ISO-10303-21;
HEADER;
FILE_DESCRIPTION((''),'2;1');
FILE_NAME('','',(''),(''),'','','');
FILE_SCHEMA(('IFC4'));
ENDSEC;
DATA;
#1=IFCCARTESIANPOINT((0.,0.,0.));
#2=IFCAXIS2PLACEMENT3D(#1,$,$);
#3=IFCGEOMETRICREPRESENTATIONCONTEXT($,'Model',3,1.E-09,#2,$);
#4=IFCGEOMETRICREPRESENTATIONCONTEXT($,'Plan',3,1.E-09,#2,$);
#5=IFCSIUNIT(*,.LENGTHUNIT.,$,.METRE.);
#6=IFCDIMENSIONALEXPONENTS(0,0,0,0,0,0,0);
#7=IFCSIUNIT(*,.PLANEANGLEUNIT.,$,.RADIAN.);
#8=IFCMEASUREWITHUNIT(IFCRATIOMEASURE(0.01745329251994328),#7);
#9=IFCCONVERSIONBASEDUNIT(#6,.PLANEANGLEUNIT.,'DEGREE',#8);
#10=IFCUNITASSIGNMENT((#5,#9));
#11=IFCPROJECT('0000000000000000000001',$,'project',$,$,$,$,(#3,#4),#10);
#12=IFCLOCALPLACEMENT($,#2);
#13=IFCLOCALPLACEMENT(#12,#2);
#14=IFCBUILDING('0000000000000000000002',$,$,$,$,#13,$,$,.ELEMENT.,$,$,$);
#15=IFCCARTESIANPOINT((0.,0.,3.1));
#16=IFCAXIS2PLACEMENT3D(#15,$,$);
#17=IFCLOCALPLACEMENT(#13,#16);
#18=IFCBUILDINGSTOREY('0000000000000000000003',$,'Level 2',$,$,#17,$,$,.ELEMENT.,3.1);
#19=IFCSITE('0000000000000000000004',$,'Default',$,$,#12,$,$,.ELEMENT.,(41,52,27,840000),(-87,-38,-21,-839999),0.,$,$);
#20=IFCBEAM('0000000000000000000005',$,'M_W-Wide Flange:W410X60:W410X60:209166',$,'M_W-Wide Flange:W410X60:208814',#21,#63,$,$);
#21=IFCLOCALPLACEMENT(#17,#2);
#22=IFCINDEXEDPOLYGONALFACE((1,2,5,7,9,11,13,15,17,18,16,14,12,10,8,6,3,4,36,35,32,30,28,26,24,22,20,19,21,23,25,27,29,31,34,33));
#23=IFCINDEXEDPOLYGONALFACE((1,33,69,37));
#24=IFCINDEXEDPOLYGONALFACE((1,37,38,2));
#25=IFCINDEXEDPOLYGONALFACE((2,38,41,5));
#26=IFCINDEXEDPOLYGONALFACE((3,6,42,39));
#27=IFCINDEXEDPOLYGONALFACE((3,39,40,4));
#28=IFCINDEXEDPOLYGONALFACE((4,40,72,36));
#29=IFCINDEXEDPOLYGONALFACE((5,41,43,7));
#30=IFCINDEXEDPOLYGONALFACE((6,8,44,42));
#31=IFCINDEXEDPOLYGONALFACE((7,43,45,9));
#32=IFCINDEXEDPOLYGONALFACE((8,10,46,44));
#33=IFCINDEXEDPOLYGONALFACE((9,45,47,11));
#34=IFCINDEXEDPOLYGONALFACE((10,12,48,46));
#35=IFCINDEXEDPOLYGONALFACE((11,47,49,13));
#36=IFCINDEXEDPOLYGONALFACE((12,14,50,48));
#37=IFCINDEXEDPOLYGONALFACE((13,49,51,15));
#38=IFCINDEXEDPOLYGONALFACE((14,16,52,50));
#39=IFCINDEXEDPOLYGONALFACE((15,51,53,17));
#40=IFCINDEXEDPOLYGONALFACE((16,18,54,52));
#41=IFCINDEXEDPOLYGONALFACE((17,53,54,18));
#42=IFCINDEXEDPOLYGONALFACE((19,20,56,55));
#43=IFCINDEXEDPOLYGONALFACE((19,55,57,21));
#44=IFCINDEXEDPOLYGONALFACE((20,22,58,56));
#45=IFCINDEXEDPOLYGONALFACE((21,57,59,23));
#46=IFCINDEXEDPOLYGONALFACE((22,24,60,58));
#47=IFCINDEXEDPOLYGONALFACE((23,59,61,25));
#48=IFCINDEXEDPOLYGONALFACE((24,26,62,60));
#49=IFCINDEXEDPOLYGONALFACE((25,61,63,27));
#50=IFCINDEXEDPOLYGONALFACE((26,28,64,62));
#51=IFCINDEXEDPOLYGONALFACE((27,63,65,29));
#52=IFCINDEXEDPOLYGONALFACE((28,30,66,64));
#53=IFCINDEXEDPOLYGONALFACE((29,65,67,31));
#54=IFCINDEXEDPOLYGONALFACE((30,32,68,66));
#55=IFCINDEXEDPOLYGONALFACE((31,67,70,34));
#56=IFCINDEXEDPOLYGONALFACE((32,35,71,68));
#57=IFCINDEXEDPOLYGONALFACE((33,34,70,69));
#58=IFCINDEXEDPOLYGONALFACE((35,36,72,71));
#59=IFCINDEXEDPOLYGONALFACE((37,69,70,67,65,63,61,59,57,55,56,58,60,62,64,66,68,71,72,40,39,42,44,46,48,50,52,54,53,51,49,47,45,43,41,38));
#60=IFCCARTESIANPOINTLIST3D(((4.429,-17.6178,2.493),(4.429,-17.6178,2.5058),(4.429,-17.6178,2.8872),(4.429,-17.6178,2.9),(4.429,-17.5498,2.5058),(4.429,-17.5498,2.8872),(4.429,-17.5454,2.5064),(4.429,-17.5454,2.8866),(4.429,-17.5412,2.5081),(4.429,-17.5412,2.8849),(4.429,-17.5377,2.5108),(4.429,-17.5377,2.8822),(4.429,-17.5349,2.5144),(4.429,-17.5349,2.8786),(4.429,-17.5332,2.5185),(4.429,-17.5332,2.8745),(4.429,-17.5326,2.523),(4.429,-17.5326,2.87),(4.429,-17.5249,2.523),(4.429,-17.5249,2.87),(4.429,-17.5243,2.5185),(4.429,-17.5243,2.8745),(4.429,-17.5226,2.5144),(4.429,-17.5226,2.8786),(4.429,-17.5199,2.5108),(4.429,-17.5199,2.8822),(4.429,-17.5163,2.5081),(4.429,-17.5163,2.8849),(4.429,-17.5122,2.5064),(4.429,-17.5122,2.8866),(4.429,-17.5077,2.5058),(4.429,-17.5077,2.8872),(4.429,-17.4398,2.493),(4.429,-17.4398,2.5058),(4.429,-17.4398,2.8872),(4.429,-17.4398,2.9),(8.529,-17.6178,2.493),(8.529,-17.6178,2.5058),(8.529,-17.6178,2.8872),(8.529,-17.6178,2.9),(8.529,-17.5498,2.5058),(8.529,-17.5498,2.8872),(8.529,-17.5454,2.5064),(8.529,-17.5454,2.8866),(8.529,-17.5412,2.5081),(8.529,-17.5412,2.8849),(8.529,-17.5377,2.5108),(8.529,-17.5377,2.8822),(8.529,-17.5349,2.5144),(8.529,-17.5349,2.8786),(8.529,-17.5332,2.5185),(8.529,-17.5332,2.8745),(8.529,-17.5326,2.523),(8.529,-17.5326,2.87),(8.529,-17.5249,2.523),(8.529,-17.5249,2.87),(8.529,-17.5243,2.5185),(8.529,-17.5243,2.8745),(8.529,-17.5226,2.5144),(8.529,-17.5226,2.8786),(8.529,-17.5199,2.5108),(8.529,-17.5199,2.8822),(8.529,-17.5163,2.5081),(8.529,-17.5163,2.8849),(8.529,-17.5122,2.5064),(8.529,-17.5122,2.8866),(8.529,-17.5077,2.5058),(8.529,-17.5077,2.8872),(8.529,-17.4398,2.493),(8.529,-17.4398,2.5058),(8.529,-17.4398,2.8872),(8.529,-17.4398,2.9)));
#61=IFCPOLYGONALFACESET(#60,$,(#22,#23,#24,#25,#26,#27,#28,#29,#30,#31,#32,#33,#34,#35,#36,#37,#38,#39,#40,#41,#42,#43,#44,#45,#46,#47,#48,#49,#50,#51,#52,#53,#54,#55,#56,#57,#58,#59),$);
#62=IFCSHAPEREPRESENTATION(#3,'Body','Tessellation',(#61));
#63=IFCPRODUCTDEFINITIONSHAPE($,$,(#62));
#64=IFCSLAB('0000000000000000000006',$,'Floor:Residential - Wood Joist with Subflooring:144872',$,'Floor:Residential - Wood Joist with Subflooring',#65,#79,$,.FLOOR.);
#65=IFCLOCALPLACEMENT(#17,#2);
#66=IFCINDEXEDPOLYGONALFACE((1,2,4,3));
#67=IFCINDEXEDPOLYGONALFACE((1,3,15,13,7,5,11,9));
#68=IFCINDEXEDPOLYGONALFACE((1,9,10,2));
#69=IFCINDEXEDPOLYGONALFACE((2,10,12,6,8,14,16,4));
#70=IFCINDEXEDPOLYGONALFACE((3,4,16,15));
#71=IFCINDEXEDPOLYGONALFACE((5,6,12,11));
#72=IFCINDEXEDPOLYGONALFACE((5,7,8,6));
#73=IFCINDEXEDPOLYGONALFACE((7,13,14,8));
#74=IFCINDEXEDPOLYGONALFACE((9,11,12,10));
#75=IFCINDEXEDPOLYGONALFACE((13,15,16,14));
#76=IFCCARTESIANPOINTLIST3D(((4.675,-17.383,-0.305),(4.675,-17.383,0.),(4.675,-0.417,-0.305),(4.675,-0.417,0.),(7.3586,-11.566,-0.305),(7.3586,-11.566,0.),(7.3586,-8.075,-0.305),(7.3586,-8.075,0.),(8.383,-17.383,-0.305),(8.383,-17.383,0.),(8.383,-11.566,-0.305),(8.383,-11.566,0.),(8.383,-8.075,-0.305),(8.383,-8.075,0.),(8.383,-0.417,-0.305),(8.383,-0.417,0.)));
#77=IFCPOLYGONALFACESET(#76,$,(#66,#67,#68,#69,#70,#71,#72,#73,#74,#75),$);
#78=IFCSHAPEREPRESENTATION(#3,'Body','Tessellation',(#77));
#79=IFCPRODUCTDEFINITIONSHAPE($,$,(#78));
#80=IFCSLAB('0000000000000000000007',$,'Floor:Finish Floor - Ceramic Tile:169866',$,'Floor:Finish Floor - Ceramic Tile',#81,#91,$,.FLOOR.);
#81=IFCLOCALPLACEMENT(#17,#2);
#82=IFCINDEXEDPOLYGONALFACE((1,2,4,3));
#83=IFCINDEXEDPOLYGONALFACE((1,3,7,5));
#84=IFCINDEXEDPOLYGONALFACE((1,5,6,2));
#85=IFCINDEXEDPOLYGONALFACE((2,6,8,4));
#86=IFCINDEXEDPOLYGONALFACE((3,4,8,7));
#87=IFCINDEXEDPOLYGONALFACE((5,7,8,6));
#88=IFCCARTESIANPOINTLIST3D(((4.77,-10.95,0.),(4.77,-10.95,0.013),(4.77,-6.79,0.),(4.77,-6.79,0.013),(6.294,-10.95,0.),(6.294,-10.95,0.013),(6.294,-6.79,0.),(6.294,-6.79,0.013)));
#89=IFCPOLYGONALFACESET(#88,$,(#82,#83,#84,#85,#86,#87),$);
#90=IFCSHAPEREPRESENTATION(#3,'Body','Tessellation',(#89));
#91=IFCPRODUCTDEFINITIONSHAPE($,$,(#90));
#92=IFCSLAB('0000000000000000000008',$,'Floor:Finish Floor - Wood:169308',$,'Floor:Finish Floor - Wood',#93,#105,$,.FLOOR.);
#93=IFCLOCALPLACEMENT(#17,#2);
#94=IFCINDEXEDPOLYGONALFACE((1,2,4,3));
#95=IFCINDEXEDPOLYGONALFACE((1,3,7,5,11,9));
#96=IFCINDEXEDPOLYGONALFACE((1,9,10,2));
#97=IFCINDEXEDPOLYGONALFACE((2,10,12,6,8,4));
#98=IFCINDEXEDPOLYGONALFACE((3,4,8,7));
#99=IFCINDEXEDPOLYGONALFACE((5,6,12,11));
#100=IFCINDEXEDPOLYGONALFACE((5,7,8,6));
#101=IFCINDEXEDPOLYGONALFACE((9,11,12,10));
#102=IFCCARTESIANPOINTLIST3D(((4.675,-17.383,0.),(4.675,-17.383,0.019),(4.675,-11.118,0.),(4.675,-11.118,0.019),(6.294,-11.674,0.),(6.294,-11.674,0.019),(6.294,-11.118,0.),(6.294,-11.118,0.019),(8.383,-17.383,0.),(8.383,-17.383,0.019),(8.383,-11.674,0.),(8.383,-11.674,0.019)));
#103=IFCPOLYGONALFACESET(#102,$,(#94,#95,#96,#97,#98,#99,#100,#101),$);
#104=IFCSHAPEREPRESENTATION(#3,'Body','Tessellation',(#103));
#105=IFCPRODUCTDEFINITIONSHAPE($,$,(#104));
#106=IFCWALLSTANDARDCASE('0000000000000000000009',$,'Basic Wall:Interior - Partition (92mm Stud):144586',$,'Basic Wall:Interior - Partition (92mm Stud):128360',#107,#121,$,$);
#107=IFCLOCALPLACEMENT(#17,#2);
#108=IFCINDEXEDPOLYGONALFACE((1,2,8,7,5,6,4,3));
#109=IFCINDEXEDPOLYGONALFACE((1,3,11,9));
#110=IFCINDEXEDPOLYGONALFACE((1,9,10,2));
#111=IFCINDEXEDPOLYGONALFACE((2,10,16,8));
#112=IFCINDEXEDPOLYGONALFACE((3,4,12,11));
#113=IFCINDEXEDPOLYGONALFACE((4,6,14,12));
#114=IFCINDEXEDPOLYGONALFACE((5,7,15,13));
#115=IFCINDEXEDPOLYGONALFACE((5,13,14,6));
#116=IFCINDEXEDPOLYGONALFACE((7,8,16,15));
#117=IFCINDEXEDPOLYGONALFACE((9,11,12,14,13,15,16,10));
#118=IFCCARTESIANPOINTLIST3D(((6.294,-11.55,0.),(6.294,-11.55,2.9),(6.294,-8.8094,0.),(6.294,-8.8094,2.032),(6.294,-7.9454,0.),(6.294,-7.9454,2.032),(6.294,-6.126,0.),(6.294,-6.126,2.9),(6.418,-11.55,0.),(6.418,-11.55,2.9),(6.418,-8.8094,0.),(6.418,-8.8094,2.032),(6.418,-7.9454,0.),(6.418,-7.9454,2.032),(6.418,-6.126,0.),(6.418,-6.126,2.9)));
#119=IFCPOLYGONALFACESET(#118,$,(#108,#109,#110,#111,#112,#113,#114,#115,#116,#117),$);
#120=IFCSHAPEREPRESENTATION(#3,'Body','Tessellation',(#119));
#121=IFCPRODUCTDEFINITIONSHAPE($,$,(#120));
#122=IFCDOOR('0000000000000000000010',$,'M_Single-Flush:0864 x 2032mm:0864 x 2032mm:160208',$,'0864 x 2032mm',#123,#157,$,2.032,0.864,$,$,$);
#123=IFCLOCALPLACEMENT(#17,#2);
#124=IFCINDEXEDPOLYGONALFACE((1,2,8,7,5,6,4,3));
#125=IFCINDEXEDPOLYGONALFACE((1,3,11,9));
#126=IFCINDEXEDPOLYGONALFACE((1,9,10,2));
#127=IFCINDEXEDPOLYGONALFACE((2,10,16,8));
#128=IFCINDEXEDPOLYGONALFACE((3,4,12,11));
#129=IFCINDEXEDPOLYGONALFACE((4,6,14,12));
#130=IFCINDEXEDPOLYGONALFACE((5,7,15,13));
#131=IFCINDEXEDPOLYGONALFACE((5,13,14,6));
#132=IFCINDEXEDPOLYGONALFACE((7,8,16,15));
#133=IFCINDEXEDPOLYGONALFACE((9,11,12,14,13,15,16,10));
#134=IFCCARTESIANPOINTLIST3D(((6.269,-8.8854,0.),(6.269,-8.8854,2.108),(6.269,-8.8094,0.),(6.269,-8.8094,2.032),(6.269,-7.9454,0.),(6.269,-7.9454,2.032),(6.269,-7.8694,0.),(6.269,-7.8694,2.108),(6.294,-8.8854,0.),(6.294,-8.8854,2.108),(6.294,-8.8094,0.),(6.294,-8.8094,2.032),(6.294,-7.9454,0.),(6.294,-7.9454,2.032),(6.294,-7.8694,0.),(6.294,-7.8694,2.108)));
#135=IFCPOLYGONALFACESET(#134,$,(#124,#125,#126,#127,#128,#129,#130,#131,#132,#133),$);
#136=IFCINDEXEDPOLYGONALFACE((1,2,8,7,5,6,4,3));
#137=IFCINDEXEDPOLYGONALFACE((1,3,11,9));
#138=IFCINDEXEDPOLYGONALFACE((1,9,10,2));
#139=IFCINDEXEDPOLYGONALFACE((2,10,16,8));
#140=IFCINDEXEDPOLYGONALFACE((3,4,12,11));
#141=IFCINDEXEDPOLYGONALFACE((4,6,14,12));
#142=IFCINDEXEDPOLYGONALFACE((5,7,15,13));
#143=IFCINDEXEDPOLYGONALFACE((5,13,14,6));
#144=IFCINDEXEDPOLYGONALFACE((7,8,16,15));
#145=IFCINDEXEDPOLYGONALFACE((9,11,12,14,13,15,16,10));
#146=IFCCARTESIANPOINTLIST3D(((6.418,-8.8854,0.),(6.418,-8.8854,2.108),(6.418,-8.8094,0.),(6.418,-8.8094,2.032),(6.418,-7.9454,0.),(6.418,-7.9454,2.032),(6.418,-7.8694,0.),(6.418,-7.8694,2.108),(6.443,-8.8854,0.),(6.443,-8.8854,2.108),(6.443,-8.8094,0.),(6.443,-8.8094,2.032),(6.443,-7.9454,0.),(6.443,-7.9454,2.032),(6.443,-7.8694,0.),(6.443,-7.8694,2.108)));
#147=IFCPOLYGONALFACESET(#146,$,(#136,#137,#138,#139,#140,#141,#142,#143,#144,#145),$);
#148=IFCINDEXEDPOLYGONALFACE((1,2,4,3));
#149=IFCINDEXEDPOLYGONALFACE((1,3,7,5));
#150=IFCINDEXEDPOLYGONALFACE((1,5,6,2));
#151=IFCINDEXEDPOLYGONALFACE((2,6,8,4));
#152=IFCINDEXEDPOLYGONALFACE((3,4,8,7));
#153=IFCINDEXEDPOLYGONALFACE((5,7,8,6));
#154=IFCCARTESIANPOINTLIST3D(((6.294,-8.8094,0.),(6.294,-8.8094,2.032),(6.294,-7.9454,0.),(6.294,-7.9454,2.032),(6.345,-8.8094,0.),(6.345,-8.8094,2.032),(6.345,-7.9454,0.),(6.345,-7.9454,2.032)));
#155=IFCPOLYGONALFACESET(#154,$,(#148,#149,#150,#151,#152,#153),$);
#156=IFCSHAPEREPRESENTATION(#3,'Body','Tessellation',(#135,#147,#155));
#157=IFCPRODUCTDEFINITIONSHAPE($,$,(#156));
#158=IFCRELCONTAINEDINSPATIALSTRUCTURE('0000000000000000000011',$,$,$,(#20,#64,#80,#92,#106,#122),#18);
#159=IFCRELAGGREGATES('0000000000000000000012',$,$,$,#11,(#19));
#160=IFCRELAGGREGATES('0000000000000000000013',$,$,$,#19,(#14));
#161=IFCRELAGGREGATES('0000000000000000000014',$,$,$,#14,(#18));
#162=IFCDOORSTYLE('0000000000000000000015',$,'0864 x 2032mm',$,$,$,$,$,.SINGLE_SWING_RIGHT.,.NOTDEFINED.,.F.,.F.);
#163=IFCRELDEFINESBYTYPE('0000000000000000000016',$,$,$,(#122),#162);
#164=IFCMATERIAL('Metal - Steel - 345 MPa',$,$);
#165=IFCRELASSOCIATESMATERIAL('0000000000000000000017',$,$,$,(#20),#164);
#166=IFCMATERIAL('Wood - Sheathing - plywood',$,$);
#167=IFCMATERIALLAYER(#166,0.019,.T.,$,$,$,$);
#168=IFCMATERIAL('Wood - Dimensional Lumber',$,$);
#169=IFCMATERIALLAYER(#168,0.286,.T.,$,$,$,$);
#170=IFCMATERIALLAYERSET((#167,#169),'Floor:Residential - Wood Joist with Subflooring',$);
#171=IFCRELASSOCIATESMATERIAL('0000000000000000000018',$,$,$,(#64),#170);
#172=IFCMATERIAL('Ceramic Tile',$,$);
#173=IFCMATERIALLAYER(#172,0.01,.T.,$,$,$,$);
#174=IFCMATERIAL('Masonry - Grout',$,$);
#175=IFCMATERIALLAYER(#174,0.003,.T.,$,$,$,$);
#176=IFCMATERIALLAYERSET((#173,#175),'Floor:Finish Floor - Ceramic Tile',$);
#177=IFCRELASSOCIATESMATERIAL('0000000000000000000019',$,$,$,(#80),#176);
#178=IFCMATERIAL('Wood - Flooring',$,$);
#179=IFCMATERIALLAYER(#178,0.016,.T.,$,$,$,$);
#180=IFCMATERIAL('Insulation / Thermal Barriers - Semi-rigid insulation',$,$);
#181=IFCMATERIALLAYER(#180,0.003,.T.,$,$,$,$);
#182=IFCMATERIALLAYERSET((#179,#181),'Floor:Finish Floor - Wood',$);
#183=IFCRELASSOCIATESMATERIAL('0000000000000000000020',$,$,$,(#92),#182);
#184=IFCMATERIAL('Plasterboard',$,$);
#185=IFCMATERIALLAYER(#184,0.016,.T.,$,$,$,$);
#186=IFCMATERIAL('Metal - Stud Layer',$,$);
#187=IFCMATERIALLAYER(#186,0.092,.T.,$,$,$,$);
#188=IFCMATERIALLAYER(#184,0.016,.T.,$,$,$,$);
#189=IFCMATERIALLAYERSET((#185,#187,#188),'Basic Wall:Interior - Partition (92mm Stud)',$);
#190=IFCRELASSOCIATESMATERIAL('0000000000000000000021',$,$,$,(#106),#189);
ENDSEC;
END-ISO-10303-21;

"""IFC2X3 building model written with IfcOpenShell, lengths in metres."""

from ifc_helpers import new_model, entity, si_unit, converted_unit, frame, frame_2d, origin, origin_2d_with_axis, place, context, project, spatial, polyline, circle_curve, parameter, trimmed, segment, composite_curve, rectangle, outline, extrude, source, transform, mapped, material, layer, layer_set, layer_usage, type_object, type_shapes, element, fill, save


model = new_model("IFC2X3")

# Units and contexts
model_context = context("Model", 3, precision=1e-09, world=origin())
plan_context = context("Plan", 3, precision=1e-09, world=origin())
ifc_project = project(units=[si_unit("LENGTHUNIT", "METRE"), converted_unit("PLANEANGLEUNIT", "DEGREE", entity("IfcRatioMeasure", 0.01745329251994328), si_unit("PLANEANGLEUNIT", "RADIAN"), dimensions=[0, 0, 0, 0, 0, 0, 0])], contexts=[model_context, plan_context])

# Site, building, storey
site_placement = place(None, origin())
site = spatial("IfcSite", under=ifc_project, at=site_placement, Name="Default", CompositionType="ELEMENT", RefLatitude=(41, 52, 27, 840000), RefLongitude=(-87, -38, -21, -839999), RefElevation=0.0)
building_placement = place(site_placement, origin())
building = spatial("IfcBuilding", under=site, at=building_placement, CompositionType="ELEMENT")
storey_placement = place(building_placement, frame((0.0, 0.0, 3.1)))
storey = spatial("IfcBuildingStorey", under=building, at=storey_placement, Name="Level 2", CompositionType="ELEMENT", Elevation=3.1)

# Beam
ifc_material_1 = material(Name="Metal - Steel - 345 MPa")
beam_placement = place(storey_placement, frame((4.429, -17.5288, 2.9), z_axis=(0.0, 0.0, 1.0), x_axis=(0.0, -1.0, 0.0)))
element("IfcBeam", 1, at=beam_placement, inside=storey, material=ifc_material_1, Name="M_W-Wide Flange:W410X60:W410X60:209166", ObjectType="M_W-Wide Flange:W410X60:208814", context=model_context, shape_type="SweptSolid", body=[
    extrude(outline(composite_curve([segment(polyline([(-0.089, -0.1907), (-0.089, -0.2035)]), True, "CONTINUOUS"), segment(polyline([(-0.089, -0.2035), (0.089, -0.2035)]), True, "CONTINUOUS"), segment(polyline([(0.089, -0.2035), (0.089, -0.1907)]), True, "CONTINUOUS"), segment(polyline([(0.089, -0.1907), (0.021, -0.1907)]), True, "CONTINUOUS"), segment(trimmed(circle_curve(frame_2d((0.021, -0.1735), x_axis=(0.0, -1.0)), 0.0172), [parameter(270.0)], [parameter(360.0)], True, "PARAMETER"), False, "CONTINUOUS"), segment(polyline([(0.0038, -0.1735), (0.0038, 0.1735)]), True, "CONTINUOUS"), segment(trimmed(circle_curve(frame_2d((0.021, 0.1735), x_axis=(-1.0, 0.0)), 0.0172), [parameter(270.0)], [parameter(360.0)], True, "PARAMETER"), False, "CONTINUOUS"), segment(polyline([(0.021, 0.1907), (0.089, 0.1907)]), True, "CONTINUOUS"), segment(polyline([(0.089, 0.1907), (0.089, 0.2035)]), True, "CONTINUOUS"), segment(polyline([(0.089, 0.2035), (-0.089, 0.2035)]), True, "CONTINUOUS"), segment(polyline([(-0.089, 0.2035), (-0.089, 0.1907)]), True, "CONTINUOUS"), segment(polyline([(-0.089, 0.1907), (-0.0211, 0.1907)]), True, "CONTINUOUS"), segment(trimmed(circle_curve(frame_2d((-0.0211, 0.1735), x_axis=(0.0, 1.0)), 0.0172), [parameter(270.0)], [parameter(0.0)], True, "PARAMETER"), False, "CONTINUOUS"), segment(polyline([(-0.0039, 0.1735), (-0.0039, -0.1735)]), True, "CONTINUOUS"), segment(trimmed(circle_curve(frame_2d((-0.0211, -0.1735), x_axis=(1.0, 0.0)), 0.0172), [parameter(270.0)], [parameter(0.0)], True, "PARAMETER"), False, "CONTINUOUS"), segment(polyline([(-0.0211, -0.1907), (-0.089, -0.1907)]), True, "CONTINUOUS")], self_intersect=False)), frame((0.0, 0.0, -0.2035), z_axis=(0.0, -1.0, 0.0), x_axis=(1.0, 0.0, 0.0)), (0.0, 0.0, -1.0), 4.1),
])

# Slabs
ifc_material_2 = material(Name="Wood - Sheathing - plywood")
ifc_layer_1 = layer(ifc_material_2, 0.019, ventilated=True)
ifc_material_3 = material(Name="Wood - Dimensional Lumber")
ifc_layer_2 = layer(ifc_material_3, 0.286, ventilated=True)
ifc_layer_set_1 = layer_set([ifc_layer_1, ifc_layer_2], Name="Floor:Residential - Wood Joist with Subflooring")
ifc_layer_usage_1 = layer_usage(ifc_layer_set_1, "AXIS3", "POSITIVE", 0.0)
slab_1_placement = place(storey_placement, frame((4.675, -17.383, -0.305)))
element("IfcSlab", 2, at=slab_1_placement, inside=storey, material=ifc_layer_usage_1, Name="Floor:Residential - Wood Joist with Subflooring:144872", ObjectType="Floor:Residential - Wood Joist with Subflooring", PredefinedType="FLOOR", context=model_context, shape_type="SweptSolid", body=[
    extrude(outline(polyline([(-1.854, 8.483), (-1.854, 0.825), (-0.8296, 0.825), (-0.8296, -2.666), (-1.854, -2.666), (-1.854, -8.483), (1.854, -8.483), (1.854, 8.483), (-1.854, 8.483)])), frame((1.854, 8.483, 0.305), z_axis=(0.0, 0.0, -1.0), x_axis=(-1.0, 0.0, 0.0)), (0.0, 0.0, 1.0), 0.305),
])
ifc_material_4 = material(Name="Wood - Flooring")
ifc_layer_3 = layer(ifc_material_4, 0.016, ventilated=True)
ifc_material_5 = material(Name="Insulation / Thermal Barriers - Semi-rigid insulation")
ifc_layer_4 = layer(ifc_material_5, 0.003, ventilated=True)
ifc_layer_set_2 = layer_set([ifc_layer_3, ifc_layer_4], Name="Floor:Finish Floor - Wood")
ifc_layer_usage_2 = layer_usage(ifc_layer_set_2, "AXIS3", "POSITIVE", 0.0)
ifc_material_6 = material(Name="Ceramic Tile")
ifc_layer_5 = layer(ifc_material_6, 0.01, ventilated=True)
ifc_material_7 = material(Name="Masonry - Grout")
ifc_layer_6 = layer(ifc_material_7, 0.003, ventilated=True)
ifc_layer_set_3 = layer_set([ifc_layer_5, ifc_layer_6], Name="Floor:Finish Floor - Ceramic Tile")
ifc_layer_usage_3 = layer_usage(ifc_layer_set_3, "AXIS3", "POSITIVE", 0.0)
slab_2_placement = place(storey_placement, frame((4.77, -10.95, 0.0)))
element("IfcSlab", 3, at=slab_2_placement, inside=storey, material=ifc_layer_usage_3, Name="Floor:Finish Floor - Ceramic Tile:169866", ObjectType="Floor:Finish Floor - Ceramic Tile", PredefinedType="FLOOR", context=model_context, shape_type="SweptSolid", body=[
    extrude(rectangle(XDim=4.16, YDim=1.524, at=frame_2d((0.0, 0.0), x_axis=(0.0, -1.0))), frame((0.762, 2.08, 0.013), z_axis=(0.0, 0.0, -1.0), x_axis=(-1.0, 0.0, 0.0)), (0.0, 0.0, 1.0), 0.013),
])
slab_3_placement = place(storey_placement, frame((4.675, -17.383, 0.0)))
element("IfcSlab", 4, at=slab_3_placement, inside=storey, material=ifc_layer_usage_2, Name="Floor:Finish Floor - Wood:169308", ObjectType="Floor:Finish Floor - Wood", PredefinedType="FLOOR", context=model_context, shape_type="SweptSolid", body=[
    extrude(outline(polyline([(-1.854, 2.5765), (-1.854, -3.1325), (1.854, -3.1325), (1.854, 3.1325), (0.235, 3.1325), (0.235, 2.5765), (-1.854, 2.5765)])), frame((1.854, 3.1325, 0.019), z_axis=(0.0, 0.0, -1.0), x_axis=(-1.0, 0.0, 0.0)), (0.0, 0.0, 1.0), 0.019),
])

# Shared definitions
ifc_material_8 = material(Name="Metal - Stud Layer")
ifc_material_9 = material(Name="Plasterboard")

# Wall, opening, door
ifc_layer_7 = layer(ifc_material_9, 0.016, ventilated=True)
ifc_layer_8 = layer(ifc_material_8, 0.092, ventilated=True)
ifc_layer_9 = layer(ifc_material_9, 0.016, ventilated=True)
ifc_layer_set_4 = layer_set([ifc_layer_7, ifc_layer_8, ifc_layer_9], Name="Basic Wall:Interior - Partition (92mm Stud)")
ifc_layer_usage_4 = layer_usage(ifc_layer_set_4, "AXIS2", "NEGATIVE", 0.062)
wall_1_placement = place(storey_placement, frame((6.356, -11.55, 0.0), z_axis=(0.0, 0.0, 1.0), x_axis=(0.0, 1.0, 0.0)))
wall_1 = element("IfcWallStandardCase", 5, at=wall_1_placement, inside=storey, material=ifc_layer_usage_4, Name="Basic Wall:Interior - Partition (92mm Stud):144586", ObjectType="Basic Wall:Interior - Partition (92mm Stud):128360", context=model_context, shape_type="SweptSolid", body=[
    extrude(rectangle(XDim=5.424, YDim=0.124, at=frame_2d((2.712, 0.0), x_axis=(-1.0, 0.0))), origin(), (0.0, 0.0, 1.0), 2.9),
])
opening_1_placement = place(wall_1_placement, frame((2.7406, -0.062, 0.0)))
opening_1 = element("IfcOpeningElement", 6, at=opening_1_placement, cuts=wall_1, ObjectType="Opening", context=model_context, shape_type="SweptSolid", body=[
    extrude(rectangle(XDim=0.864, YDim=2.032, at=frame_2d((1.016, 0.432), x_axis=(0.0, 1.0))), frame((0.0, 0.0, 0.0), z_axis=(0.0, 1.0, 0.0), x_axis=(0.0, 0.0, 1.0)), (0.0, 0.0, 1.0), 0.124),
])
door_style = type_object("IfcDoorStyle", Name="0864 x 2032mm", ConstructionType="NOTDEFINED", OperationType="SINGLE_SWING_RIGHT", ParameterTakesPrecedence=False, Sizeable=False)
shared_shape_1 = source(origin(), model_context, "Body", "SweptSolid", [
    extrude(outline(polyline([(-0.508, -1.073), (0.508, -1.073), (0.508, 1.035), (0.432, 1.035), (0.432, -0.997), (-0.432, -0.997), (-0.432, 1.035), (-0.508, 1.035), (-0.508, -1.073)])), frame((0.432, 0.124, 1.035), z_axis=(0.0, 1.0, 0.0), x_axis=(1.0, 0.0, 0.0)), (0.0, 0.0, 1.0), 0.025),
    extrude(outline(polyline([(-1.073, -0.508), (1.035, -0.508), (1.035, -0.432), (-0.997, -0.432), (-0.997, 0.432), (1.035, 0.432), (1.035, 0.508), (-1.073, 0.508), (-1.073, -0.508)])), frame((0.432, -0.025, 1.035), z_axis=(0.0, 1.0, 0.0), x_axis=(0.0, 0.0, -1.0)), (0.0, 0.0, 1.0), 0.025),
    extrude(rectangle(XDim=0.051, YDim=0.864, at=origin_2d_with_axis()), frame((0.432, 0.0985, 0.0), z_axis=(0.0, 0.0, 1.0), x_axis=(0.0, 1.0, 0.0)), (0.0, 0.0, 1.0), 2.032),
])
type_shapes(door_style, [shared_shape_1])
door_placement = place(opening_1_placement, origin())
door = element("IfcDoor", 7, at=door_placement, inside=storey, type_object=door_style, Name="M_Single-Flush:0864 x 2032mm:0864 x 2032mm:160208", ObjectType="0864 x 2032mm", OverallHeight=2.032, OverallWidth=0.864, context=model_context, shape_type="MappedRepresentation", body=[
    mapped(shared_shape_1, transform((0.0, 0.0, 0.0), scale=1.0)),
])
fill(opening_1, door)

save(model, "model.ifc")
